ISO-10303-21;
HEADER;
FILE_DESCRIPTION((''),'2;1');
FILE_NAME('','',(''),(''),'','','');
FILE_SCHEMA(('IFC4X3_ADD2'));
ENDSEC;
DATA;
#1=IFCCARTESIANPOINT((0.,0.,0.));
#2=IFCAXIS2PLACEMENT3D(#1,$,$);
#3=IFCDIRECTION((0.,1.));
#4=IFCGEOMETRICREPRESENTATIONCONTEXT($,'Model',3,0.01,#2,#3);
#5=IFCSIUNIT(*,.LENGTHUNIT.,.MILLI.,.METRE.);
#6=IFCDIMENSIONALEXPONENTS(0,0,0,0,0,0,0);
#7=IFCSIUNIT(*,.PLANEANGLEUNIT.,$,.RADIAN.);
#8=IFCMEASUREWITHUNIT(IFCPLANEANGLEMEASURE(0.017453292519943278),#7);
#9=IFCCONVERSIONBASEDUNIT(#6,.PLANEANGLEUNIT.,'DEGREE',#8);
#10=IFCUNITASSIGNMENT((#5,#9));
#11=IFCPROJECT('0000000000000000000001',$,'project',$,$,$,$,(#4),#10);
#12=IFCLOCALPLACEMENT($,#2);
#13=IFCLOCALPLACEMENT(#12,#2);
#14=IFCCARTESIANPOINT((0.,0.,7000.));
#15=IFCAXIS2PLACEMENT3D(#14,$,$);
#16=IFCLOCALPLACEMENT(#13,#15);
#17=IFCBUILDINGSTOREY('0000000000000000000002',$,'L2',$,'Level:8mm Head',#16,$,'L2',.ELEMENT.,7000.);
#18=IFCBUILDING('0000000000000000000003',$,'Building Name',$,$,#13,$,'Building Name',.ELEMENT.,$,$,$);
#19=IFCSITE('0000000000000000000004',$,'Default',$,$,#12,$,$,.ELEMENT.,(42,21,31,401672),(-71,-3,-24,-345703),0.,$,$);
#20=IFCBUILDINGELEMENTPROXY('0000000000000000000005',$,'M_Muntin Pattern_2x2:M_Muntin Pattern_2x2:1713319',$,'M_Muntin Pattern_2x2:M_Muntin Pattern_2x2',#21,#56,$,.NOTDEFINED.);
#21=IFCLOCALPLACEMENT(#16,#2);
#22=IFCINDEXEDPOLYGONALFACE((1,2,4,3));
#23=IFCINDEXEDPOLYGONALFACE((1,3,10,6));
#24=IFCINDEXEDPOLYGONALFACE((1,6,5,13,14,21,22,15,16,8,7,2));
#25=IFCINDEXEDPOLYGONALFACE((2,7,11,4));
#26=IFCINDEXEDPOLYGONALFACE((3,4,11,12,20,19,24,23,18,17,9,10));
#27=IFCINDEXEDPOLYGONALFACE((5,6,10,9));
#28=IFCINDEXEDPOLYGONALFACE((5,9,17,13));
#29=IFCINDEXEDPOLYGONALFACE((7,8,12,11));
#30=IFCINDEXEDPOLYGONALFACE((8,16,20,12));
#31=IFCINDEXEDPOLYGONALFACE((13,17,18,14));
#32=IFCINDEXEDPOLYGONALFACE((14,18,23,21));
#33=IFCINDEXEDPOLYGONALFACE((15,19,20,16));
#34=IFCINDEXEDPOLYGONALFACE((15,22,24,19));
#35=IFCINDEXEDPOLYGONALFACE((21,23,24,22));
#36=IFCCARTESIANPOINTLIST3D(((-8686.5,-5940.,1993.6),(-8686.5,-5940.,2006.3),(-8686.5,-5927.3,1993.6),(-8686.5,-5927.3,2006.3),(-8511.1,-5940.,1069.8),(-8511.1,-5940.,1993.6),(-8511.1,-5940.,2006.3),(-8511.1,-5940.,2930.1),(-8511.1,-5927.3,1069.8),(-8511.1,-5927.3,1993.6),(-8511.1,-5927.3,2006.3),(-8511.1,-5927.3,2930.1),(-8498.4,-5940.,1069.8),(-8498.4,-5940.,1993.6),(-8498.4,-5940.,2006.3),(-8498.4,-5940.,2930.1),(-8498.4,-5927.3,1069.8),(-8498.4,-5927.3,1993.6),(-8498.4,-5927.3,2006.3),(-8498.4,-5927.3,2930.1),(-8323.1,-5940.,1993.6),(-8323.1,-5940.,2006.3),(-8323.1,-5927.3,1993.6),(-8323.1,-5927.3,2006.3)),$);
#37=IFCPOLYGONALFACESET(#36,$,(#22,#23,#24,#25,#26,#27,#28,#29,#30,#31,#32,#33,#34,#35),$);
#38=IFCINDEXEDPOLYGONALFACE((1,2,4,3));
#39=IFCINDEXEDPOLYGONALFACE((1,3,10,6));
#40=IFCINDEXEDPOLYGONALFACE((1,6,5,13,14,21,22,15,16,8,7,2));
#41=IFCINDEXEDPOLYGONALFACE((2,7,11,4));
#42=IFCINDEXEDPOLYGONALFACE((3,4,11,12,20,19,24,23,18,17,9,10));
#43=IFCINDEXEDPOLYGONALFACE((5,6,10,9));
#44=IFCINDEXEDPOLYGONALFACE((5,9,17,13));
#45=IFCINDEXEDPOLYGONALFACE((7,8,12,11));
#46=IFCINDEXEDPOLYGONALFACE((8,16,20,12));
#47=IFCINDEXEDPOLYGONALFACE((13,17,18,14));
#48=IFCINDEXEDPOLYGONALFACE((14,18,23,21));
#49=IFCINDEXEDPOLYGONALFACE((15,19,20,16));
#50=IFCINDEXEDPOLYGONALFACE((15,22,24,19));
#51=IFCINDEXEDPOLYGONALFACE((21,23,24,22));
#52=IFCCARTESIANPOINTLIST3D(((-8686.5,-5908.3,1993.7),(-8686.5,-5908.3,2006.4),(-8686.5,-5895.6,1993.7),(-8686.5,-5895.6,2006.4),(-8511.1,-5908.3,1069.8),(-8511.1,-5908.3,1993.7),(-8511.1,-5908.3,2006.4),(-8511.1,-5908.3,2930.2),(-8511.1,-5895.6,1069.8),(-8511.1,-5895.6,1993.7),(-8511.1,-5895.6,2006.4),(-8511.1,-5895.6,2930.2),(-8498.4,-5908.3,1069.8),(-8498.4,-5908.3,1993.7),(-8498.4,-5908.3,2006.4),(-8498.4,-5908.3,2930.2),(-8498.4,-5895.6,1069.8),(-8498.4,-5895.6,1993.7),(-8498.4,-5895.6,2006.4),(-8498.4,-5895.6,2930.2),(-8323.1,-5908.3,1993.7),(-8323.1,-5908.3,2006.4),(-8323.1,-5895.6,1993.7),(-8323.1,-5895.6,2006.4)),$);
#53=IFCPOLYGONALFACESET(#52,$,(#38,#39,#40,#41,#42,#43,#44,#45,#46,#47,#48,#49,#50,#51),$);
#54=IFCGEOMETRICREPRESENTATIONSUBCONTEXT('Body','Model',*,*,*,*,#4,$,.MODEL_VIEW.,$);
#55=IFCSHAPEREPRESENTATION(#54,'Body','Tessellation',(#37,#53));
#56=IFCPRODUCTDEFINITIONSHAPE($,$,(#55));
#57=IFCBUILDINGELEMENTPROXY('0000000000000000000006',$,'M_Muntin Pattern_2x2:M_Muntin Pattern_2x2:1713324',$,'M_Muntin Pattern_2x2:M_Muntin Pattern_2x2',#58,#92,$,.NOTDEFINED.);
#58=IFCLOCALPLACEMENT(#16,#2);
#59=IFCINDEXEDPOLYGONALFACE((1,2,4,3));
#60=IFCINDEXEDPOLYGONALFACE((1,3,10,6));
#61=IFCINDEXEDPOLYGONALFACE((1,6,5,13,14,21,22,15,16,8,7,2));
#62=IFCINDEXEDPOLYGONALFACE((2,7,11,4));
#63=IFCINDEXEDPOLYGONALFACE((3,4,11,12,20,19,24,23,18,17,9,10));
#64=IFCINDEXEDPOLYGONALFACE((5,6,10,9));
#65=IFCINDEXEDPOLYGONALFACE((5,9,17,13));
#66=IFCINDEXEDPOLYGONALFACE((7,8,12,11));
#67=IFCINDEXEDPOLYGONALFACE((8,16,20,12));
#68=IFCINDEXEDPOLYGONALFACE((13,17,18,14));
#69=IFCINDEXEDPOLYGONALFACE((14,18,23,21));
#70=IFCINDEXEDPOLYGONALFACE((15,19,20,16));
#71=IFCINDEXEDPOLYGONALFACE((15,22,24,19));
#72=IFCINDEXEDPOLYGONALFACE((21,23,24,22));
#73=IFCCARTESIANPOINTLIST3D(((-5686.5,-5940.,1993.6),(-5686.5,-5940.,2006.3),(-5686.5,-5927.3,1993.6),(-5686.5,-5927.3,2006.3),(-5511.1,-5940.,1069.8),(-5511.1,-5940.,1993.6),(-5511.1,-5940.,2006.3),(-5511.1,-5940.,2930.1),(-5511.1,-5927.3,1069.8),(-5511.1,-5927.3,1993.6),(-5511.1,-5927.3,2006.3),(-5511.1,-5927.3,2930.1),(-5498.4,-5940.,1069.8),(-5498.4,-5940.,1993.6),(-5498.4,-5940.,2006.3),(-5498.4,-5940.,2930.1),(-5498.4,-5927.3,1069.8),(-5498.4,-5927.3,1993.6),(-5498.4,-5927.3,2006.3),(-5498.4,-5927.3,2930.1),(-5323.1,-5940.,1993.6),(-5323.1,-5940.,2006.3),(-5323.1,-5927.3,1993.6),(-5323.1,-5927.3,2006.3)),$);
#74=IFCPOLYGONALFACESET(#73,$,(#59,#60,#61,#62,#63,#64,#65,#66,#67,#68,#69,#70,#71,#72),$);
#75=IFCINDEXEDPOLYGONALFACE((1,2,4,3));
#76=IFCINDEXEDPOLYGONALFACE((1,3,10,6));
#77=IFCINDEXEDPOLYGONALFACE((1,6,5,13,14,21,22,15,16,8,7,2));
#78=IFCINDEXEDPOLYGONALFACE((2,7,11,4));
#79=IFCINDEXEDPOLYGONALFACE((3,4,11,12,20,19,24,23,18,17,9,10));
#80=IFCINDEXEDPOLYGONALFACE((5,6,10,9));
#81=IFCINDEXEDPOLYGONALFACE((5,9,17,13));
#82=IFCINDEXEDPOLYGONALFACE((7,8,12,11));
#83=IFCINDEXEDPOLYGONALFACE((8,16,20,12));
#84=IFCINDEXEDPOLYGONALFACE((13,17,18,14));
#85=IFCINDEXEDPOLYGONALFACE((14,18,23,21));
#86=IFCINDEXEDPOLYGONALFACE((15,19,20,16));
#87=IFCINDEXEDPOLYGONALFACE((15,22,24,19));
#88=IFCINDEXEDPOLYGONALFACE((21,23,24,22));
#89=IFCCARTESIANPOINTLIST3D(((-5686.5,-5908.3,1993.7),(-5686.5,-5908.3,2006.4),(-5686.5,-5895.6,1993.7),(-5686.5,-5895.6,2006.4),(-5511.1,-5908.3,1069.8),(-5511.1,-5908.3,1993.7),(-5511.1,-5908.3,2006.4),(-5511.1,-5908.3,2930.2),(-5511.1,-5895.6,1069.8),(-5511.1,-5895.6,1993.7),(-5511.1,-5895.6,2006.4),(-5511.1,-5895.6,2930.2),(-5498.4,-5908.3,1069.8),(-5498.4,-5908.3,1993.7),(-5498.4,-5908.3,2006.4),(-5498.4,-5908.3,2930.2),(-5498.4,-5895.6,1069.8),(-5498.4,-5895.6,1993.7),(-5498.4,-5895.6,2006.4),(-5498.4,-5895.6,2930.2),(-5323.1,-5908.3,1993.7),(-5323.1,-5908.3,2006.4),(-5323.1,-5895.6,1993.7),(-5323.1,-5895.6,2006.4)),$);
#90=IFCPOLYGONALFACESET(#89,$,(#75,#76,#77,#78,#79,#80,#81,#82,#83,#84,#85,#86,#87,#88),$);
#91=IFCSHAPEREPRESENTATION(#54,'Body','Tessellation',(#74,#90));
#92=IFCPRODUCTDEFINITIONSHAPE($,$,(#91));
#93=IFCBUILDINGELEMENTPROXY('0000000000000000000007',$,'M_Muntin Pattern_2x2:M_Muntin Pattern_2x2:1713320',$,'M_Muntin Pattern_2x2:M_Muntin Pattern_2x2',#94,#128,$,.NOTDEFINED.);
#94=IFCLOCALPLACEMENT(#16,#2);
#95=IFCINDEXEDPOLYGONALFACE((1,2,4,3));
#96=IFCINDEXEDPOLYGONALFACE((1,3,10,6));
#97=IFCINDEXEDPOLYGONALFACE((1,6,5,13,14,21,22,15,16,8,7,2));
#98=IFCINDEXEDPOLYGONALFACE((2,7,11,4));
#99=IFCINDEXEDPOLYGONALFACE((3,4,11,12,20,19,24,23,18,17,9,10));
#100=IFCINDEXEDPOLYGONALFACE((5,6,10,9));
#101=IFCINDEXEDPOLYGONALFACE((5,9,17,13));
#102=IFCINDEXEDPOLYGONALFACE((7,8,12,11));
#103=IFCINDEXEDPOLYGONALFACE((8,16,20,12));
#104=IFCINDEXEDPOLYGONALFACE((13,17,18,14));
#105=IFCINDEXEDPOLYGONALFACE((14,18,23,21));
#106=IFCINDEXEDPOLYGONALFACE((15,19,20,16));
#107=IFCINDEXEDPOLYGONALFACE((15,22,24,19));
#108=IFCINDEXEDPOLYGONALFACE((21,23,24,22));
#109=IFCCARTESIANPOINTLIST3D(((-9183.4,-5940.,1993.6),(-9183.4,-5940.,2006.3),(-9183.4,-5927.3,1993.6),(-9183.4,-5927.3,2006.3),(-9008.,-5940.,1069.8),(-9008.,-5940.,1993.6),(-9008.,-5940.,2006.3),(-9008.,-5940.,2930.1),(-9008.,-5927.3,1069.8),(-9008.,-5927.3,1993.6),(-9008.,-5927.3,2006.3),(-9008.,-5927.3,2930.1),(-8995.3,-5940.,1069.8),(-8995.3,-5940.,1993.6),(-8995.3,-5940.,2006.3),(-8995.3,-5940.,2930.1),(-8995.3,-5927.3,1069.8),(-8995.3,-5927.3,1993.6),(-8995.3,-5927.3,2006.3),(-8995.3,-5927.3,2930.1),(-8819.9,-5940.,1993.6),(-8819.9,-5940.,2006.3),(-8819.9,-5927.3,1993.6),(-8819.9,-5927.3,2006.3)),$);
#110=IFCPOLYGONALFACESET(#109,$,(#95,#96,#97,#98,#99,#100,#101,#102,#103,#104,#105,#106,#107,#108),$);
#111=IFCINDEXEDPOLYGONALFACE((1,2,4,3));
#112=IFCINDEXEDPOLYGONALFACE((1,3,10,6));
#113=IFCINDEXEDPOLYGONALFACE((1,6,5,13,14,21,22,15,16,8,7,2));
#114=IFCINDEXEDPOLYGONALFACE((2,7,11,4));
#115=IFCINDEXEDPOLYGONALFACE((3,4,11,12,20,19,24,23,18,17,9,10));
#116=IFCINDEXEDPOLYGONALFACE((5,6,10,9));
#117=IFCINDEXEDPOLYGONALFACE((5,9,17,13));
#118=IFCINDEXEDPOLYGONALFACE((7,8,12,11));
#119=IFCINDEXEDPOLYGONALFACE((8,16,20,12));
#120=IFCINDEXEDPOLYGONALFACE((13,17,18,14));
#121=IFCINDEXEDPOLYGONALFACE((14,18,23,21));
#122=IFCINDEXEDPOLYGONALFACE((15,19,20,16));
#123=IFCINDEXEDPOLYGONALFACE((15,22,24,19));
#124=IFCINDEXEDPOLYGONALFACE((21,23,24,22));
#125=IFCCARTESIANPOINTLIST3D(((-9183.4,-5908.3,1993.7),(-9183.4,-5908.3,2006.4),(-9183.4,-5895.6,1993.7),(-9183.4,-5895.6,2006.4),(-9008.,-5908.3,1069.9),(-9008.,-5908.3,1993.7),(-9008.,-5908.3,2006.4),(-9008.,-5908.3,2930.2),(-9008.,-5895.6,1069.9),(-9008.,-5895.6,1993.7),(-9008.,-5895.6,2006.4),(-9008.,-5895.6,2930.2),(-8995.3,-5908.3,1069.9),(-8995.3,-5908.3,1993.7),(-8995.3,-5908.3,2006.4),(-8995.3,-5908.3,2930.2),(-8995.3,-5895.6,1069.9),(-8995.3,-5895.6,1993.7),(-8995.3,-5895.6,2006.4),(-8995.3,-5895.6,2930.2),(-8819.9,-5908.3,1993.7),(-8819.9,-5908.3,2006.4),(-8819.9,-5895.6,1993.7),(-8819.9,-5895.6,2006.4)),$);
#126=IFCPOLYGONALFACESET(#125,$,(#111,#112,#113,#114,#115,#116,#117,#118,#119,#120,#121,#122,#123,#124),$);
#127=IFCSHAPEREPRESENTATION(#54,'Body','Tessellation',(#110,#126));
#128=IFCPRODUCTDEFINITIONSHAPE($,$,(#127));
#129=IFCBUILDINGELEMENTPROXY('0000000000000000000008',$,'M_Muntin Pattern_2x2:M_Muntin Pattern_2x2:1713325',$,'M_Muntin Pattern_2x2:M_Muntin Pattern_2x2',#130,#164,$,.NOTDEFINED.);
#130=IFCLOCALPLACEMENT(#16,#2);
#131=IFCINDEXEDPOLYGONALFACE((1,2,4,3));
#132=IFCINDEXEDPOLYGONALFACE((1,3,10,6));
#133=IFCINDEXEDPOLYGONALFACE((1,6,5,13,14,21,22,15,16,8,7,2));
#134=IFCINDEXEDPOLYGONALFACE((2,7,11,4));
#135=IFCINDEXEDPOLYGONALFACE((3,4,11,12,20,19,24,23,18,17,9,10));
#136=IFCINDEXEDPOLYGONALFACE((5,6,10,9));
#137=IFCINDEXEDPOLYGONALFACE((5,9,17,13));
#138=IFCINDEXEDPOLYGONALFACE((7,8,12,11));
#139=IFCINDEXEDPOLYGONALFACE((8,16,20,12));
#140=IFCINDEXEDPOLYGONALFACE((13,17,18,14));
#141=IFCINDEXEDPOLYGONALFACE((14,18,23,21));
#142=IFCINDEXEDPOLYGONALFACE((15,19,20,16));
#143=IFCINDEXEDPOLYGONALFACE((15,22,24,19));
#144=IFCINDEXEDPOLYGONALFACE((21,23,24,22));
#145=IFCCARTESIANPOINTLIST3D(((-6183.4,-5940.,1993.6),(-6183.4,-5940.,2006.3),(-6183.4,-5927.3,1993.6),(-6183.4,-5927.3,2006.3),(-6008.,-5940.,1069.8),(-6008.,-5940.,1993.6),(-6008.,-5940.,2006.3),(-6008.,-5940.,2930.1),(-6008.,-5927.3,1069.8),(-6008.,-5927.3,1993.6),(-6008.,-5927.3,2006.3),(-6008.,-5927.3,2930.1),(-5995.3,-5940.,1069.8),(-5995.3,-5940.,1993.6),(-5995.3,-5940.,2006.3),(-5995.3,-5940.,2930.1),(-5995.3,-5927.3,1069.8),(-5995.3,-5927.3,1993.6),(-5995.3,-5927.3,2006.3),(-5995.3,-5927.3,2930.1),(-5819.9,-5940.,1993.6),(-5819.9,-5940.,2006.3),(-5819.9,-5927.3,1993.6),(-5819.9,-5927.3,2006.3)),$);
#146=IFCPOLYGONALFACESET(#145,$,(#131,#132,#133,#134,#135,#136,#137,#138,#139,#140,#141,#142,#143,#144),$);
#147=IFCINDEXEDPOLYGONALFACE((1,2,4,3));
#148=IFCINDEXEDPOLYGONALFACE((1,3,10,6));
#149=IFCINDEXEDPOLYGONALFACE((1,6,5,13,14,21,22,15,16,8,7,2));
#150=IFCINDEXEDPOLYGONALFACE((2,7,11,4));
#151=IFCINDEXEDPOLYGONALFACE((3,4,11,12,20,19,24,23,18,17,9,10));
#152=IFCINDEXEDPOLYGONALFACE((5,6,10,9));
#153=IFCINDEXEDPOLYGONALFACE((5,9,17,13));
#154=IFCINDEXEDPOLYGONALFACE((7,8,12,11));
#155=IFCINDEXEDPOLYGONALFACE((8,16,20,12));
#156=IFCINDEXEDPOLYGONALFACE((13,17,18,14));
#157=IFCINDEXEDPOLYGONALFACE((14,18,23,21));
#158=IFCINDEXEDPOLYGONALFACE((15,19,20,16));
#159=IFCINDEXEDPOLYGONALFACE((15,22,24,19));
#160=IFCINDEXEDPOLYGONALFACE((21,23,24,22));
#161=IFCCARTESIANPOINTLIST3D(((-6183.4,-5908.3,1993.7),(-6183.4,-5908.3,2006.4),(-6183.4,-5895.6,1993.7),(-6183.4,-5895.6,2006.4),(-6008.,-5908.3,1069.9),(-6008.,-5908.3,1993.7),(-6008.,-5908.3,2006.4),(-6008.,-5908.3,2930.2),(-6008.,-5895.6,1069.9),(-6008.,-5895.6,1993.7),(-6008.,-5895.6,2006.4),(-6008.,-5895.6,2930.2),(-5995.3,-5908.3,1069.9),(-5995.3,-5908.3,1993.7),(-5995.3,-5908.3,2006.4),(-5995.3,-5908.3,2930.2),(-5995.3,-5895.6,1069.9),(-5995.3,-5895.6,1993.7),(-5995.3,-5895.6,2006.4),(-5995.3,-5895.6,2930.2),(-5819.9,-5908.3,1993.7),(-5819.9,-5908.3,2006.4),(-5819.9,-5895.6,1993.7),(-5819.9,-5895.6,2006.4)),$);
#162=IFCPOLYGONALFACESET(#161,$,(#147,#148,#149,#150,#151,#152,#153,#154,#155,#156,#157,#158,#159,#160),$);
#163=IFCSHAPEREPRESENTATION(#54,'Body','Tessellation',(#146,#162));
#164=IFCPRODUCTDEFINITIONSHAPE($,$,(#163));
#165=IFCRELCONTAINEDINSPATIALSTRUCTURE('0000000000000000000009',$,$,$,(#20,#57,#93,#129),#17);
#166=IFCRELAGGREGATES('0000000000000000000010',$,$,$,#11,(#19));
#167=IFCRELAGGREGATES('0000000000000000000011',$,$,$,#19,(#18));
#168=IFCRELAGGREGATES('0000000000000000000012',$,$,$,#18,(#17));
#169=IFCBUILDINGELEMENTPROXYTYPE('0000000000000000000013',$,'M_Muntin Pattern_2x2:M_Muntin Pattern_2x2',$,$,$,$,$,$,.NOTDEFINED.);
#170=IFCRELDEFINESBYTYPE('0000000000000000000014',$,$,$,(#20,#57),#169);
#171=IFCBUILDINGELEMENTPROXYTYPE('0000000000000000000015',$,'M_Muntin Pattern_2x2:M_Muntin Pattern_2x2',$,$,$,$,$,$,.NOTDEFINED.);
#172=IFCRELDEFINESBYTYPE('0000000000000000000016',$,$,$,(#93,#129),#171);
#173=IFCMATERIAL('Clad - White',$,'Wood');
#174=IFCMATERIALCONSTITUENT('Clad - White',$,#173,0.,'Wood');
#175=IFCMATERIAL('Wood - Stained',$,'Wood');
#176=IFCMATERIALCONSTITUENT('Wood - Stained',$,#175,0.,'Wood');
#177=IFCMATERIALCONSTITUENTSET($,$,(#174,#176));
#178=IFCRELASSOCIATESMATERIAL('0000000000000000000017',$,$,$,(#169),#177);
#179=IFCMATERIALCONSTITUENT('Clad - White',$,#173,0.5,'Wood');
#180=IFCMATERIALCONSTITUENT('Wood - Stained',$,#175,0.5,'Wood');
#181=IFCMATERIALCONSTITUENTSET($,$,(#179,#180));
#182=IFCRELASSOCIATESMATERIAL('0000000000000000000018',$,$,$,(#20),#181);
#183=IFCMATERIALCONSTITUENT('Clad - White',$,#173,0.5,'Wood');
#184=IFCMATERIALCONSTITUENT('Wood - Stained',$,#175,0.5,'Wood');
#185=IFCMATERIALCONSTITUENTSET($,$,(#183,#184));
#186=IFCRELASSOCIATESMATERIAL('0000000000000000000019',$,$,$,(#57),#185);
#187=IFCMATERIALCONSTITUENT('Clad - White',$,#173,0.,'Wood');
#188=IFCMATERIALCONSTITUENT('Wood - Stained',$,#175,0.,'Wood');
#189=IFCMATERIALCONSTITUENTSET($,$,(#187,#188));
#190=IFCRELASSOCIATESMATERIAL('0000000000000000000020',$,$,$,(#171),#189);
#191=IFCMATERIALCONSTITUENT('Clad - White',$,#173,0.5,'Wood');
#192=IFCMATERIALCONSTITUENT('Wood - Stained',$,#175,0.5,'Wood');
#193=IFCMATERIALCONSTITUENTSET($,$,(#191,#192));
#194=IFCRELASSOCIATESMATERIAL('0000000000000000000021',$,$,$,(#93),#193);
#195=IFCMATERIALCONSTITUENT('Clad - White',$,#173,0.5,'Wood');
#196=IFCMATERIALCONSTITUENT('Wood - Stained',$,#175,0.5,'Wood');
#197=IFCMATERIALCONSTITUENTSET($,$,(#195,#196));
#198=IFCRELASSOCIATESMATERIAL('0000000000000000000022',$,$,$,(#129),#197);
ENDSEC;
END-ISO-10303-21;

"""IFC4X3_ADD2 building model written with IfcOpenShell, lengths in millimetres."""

from ifc_helpers import new_model, entity, si_unit, converted_unit, direction, frame, origin, place, context, subcontext, project, spatial, polyline, outline, extrude, source, transform, mapped, material, constituent, constituent_set, type_object, type_shapes, element, save


model = new_model("IFC4X3_ADD2")

# Units and contexts
model_context = context("Model", 3, precision=0.01, world=origin(), true_north=direction((0.0, 1.0)))
body_context = subcontext(model_context, "Body", "Model", "MODEL_VIEW")
ifc_project = project(units=[si_unit("LENGTHUNIT", "METRE", prefix="MILLI"), converted_unit("PLANEANGLEUNIT", "DEGREE", entity("IfcPlaneAngleMeasure", 0.017453292519943278), si_unit("PLANEANGLEUNIT", "RADIAN"), dimensions=[0, 0, 0, 0, 0, 0, 0])], contexts=[model_context])

# Site, building, storey
site_placement = place(None, origin())
site = spatial("IfcSite", under=ifc_project, at=site_placement, Name="Default", CompositionType="ELEMENT", RefLatitude=(42, 21, 31, 401672), RefLongitude=(-71, -3, -24, -345703), RefElevation=0.0)
building_placement = place(site_placement, origin())
building = spatial("IfcBuilding", under=site, at=building_placement, Name="Building Name", LongName="Building Name", CompositionType="ELEMENT")
storey_placement = place(building_placement, frame((0.0, 0.0, 7000.0)))
storey = spatial("IfcBuildingStorey", under=building, at=storey_placement, Name="L2", ObjectType="Level:8mm Head", LongName="L2", CompositionType="ELEMENT", Elevation=7000.0)

# Shared definitions
ifc_material_1 = material(Name="Clad - White", Category="Wood")
ifc_material_2 = material(Name="Wood - Stained", Category="Wood")

# Building element proxies
ifc_constituent_1 = constituent(ifc_material_1, Name="Clad - White", Category="Wood", fraction=0.5)
ifc_constituent_2 = constituent(ifc_material_2, Name="Wood - Stained", Category="Wood", fraction=0.5)
ifc_constituent_set_1 = constituent_set(constituents=[ifc_constituent_1, ifc_constituent_2])
ifc_constituent_3 = constituent(ifc_material_1, Name="Clad - White", Category="Wood", fraction=0.0)
ifc_constituent_4 = constituent(ifc_material_2, Name="Wood - Stained", Category="Wood", fraction=0.0)
ifc_constituent_set_2 = constituent_set(constituents=[ifc_constituent_3, ifc_constituent_4])
building_element_proxy_type_1 = type_object("IfcBuildingElementProxyType", Name="M_Muntin Pattern_2x2:M_Muntin Pattern_2x2", PredefinedType="NOTDEFINED", material=ifc_constituent_set_2)
shared_shape_1 = source(origin(), body_context, "Body", "SweptSolid", [
    extrude(outline(polyline([(6.4, -6.4), (930.1, -6.4), (930.1, 6.3), (6.4, 6.3), (6.4, 181.7), (-6.3, 181.7), (-6.3, 6.3), (-930.2, 6.3), (-930.2, -6.4), (-6.3, -6.4), (-6.3, -181.7), (6.4, -181.7), (6.4, -6.4)])), frame((0.0, 9.5, 930.1), z_axis=(0.0, 1.0, 0.0), x_axis=(0.0, 0.0, 1.0)), (0.0, 0.0, 1.0), 12.7),
    extrude(outline(polyline([(6.4, -6.4), (930.2, -6.4), (930.2, 6.3), (6.4, 6.3), (6.4, 181.7), (-6.3, 181.7), (-6.3, 6.3), (-930.2, 6.3), (-930.2, -6.4), (-6.3, -6.4), (-6.3, -181.7), (6.4, -181.7), (6.4, -6.4)])), frame((0.0, -22.2, 930.2), z_axis=(0.0, 1.0, 0.0), x_axis=(0.0, 0.0, 1.0)), (0.0, 0.0, 1.0), 12.7),
])
type_shapes(building_element_proxy_type_1, [shared_shape_1])
proxy_1_placement = place(storey_placement, frame((-8504.8, -5917.8, 1069.8), z_axis=(0.0, 0.0, 1.0), x_axis=(-1.0, 0.0, 0.0)))
element("IfcBuildingElementProxy", 1, at=proxy_1_placement, inside=storey, type_object=building_element_proxy_type_1, material=ifc_constituent_set_1, Name="M_Muntin Pattern_2x2:M_Muntin Pattern_2x2:1713319", ObjectType="M_Muntin Pattern_2x2:M_Muntin Pattern_2x2", PredefinedType="NOTDEFINED", context=body_context, shape_type="MappedRepresentation", body=[
    mapped(shared_shape_1, transform((0.0, 0.0, 0.0), scale=1.0)),
])
ifc_constituent_5 = constituent(ifc_material_1, Name="Clad - White", Category="Wood", fraction=0.5)
ifc_constituent_6 = constituent(ifc_material_2, Name="Wood - Stained", Category="Wood", fraction=0.5)
ifc_constituent_set_3 = constituent_set(constituents=[ifc_constituent_5, ifc_constituent_6])
proxy_2_placement = place(storey_placement, frame((-5504.8, -5917.8, 1069.8), z_axis=(0.0, 0.0, 1.0), x_axis=(-1.0, 0.0, 0.0)))
element("IfcBuildingElementProxy", 2, at=proxy_2_placement, inside=storey, type_object=building_element_proxy_type_1, material=ifc_constituent_set_3, Name="M_Muntin Pattern_2x2:M_Muntin Pattern_2x2:1713324", ObjectType="M_Muntin Pattern_2x2:M_Muntin Pattern_2x2", PredefinedType="NOTDEFINED", context=body_context, shape_type="MappedRepresentation", body=[
    mapped(shared_shape_1, transform((0.0, 0.0, 0.0), scale=1.0)),
])
ifc_constituent_7 = constituent(ifc_material_1, Name="Clad - White", Category="Wood", fraction=0.5)
ifc_constituent_8 = constituent(ifc_material_2, Name="Wood - Stained", Category="Wood", fraction=0.5)
ifc_constituent_set_4 = constituent_set(constituents=[ifc_constituent_7, ifc_constituent_8])
ifc_constituent_9 = constituent(ifc_material_1, Name="Clad - White", Category="Wood", fraction=0.0)
ifc_constituent_10 = constituent(ifc_material_2, Name="Wood - Stained", Category="Wood", fraction=0.0)
ifc_constituent_set_5 = constituent_set(constituents=[ifc_constituent_9, ifc_constituent_10])
building_element_proxy_type_2 = type_object("IfcBuildingElementProxyType", Name="M_Muntin Pattern_2x2:M_Muntin Pattern_2x2", PredefinedType="NOTDEFINED", material=ifc_constituent_set_5)
shared_shape_2 = source(origin(), body_context, "Body", "SweptSolid", [
    extrude(outline(polyline([(6.4, -6.4), (930.1, -6.4), (930.1, 6.3), (6.4, 6.3), (6.4, 181.7), (-6.3, 181.7), (-6.3, 6.3), (-930.2, 6.3), (-930.2, -6.4), (-6.3, -6.4), (-6.3, -181.7), (6.4, -181.7), (6.4, -6.4)])), frame((0.0, -22.2, 930.1), z_axis=(0.0, 1.0, 0.0), x_axis=(0.0, 0.0, 1.0)), (0.0, 0.0, 1.0), 12.7),
    extrude(outline(polyline([(6.4, -6.4), (930.2, -6.4), (930.2, 6.3), (6.4, 6.3), (6.4, 181.7), (-6.3, 181.7), (-6.3, 6.3), (-930.2, 6.3), (-930.2, -6.4), (-6.3, -6.4), (-6.3, -181.7), (6.4, -181.7), (6.4, -6.4)])), frame((0.0, 9.5, 930.2), z_axis=(0.0, 1.0, 0.0), x_axis=(0.0, 0.0, 1.0)), (0.0, 0.0, 1.0), 12.7),
])
type_shapes(building_element_proxy_type_2, [shared_shape_2])
proxy_3_placement = place(storey_placement, frame((-9001.6, -5917.8, 1069.9)))
element("IfcBuildingElementProxy", 3, at=proxy_3_placement, inside=storey, type_object=building_element_proxy_type_2, material=ifc_constituent_set_4, Name="M_Muntin Pattern_2x2:M_Muntin Pattern_2x2:1713320", ObjectType="M_Muntin Pattern_2x2:M_Muntin Pattern_2x2", PredefinedType="NOTDEFINED", context=body_context, shape_type="MappedRepresentation", body=[
    mapped(shared_shape_2, transform((0.0, 0.0, 0.0), scale=1.0)),
])
ifc_constituent_11 = constituent(ifc_material_1, Name="Clad - White", Category="Wood", fraction=0.5)
ifc_constituent_12 = constituent(ifc_material_2, Name="Wood - Stained", Category="Wood", fraction=0.5)
ifc_constituent_set_6 = constituent_set(constituents=[ifc_constituent_11, ifc_constituent_12])
proxy_4_placement = place(storey_placement, frame((-6001.6, -5917.8, 1069.9)))
element("IfcBuildingElementProxy", 4, at=proxy_4_placement, inside=storey, type_object=building_element_proxy_type_2, material=ifc_constituent_set_6, Name="M_Muntin Pattern_2x2:M_Muntin Pattern_2x2:1713325", ObjectType="M_Muntin Pattern_2x2:M_Muntin Pattern_2x2", PredefinedType="NOTDEFINED", context=body_context, shape_type="MappedRepresentation", body=[
    mapped(shared_shape_2, transform((0.0, 0.0, 0.0), scale=1.0)),
])

save(model, "model.ifc")
